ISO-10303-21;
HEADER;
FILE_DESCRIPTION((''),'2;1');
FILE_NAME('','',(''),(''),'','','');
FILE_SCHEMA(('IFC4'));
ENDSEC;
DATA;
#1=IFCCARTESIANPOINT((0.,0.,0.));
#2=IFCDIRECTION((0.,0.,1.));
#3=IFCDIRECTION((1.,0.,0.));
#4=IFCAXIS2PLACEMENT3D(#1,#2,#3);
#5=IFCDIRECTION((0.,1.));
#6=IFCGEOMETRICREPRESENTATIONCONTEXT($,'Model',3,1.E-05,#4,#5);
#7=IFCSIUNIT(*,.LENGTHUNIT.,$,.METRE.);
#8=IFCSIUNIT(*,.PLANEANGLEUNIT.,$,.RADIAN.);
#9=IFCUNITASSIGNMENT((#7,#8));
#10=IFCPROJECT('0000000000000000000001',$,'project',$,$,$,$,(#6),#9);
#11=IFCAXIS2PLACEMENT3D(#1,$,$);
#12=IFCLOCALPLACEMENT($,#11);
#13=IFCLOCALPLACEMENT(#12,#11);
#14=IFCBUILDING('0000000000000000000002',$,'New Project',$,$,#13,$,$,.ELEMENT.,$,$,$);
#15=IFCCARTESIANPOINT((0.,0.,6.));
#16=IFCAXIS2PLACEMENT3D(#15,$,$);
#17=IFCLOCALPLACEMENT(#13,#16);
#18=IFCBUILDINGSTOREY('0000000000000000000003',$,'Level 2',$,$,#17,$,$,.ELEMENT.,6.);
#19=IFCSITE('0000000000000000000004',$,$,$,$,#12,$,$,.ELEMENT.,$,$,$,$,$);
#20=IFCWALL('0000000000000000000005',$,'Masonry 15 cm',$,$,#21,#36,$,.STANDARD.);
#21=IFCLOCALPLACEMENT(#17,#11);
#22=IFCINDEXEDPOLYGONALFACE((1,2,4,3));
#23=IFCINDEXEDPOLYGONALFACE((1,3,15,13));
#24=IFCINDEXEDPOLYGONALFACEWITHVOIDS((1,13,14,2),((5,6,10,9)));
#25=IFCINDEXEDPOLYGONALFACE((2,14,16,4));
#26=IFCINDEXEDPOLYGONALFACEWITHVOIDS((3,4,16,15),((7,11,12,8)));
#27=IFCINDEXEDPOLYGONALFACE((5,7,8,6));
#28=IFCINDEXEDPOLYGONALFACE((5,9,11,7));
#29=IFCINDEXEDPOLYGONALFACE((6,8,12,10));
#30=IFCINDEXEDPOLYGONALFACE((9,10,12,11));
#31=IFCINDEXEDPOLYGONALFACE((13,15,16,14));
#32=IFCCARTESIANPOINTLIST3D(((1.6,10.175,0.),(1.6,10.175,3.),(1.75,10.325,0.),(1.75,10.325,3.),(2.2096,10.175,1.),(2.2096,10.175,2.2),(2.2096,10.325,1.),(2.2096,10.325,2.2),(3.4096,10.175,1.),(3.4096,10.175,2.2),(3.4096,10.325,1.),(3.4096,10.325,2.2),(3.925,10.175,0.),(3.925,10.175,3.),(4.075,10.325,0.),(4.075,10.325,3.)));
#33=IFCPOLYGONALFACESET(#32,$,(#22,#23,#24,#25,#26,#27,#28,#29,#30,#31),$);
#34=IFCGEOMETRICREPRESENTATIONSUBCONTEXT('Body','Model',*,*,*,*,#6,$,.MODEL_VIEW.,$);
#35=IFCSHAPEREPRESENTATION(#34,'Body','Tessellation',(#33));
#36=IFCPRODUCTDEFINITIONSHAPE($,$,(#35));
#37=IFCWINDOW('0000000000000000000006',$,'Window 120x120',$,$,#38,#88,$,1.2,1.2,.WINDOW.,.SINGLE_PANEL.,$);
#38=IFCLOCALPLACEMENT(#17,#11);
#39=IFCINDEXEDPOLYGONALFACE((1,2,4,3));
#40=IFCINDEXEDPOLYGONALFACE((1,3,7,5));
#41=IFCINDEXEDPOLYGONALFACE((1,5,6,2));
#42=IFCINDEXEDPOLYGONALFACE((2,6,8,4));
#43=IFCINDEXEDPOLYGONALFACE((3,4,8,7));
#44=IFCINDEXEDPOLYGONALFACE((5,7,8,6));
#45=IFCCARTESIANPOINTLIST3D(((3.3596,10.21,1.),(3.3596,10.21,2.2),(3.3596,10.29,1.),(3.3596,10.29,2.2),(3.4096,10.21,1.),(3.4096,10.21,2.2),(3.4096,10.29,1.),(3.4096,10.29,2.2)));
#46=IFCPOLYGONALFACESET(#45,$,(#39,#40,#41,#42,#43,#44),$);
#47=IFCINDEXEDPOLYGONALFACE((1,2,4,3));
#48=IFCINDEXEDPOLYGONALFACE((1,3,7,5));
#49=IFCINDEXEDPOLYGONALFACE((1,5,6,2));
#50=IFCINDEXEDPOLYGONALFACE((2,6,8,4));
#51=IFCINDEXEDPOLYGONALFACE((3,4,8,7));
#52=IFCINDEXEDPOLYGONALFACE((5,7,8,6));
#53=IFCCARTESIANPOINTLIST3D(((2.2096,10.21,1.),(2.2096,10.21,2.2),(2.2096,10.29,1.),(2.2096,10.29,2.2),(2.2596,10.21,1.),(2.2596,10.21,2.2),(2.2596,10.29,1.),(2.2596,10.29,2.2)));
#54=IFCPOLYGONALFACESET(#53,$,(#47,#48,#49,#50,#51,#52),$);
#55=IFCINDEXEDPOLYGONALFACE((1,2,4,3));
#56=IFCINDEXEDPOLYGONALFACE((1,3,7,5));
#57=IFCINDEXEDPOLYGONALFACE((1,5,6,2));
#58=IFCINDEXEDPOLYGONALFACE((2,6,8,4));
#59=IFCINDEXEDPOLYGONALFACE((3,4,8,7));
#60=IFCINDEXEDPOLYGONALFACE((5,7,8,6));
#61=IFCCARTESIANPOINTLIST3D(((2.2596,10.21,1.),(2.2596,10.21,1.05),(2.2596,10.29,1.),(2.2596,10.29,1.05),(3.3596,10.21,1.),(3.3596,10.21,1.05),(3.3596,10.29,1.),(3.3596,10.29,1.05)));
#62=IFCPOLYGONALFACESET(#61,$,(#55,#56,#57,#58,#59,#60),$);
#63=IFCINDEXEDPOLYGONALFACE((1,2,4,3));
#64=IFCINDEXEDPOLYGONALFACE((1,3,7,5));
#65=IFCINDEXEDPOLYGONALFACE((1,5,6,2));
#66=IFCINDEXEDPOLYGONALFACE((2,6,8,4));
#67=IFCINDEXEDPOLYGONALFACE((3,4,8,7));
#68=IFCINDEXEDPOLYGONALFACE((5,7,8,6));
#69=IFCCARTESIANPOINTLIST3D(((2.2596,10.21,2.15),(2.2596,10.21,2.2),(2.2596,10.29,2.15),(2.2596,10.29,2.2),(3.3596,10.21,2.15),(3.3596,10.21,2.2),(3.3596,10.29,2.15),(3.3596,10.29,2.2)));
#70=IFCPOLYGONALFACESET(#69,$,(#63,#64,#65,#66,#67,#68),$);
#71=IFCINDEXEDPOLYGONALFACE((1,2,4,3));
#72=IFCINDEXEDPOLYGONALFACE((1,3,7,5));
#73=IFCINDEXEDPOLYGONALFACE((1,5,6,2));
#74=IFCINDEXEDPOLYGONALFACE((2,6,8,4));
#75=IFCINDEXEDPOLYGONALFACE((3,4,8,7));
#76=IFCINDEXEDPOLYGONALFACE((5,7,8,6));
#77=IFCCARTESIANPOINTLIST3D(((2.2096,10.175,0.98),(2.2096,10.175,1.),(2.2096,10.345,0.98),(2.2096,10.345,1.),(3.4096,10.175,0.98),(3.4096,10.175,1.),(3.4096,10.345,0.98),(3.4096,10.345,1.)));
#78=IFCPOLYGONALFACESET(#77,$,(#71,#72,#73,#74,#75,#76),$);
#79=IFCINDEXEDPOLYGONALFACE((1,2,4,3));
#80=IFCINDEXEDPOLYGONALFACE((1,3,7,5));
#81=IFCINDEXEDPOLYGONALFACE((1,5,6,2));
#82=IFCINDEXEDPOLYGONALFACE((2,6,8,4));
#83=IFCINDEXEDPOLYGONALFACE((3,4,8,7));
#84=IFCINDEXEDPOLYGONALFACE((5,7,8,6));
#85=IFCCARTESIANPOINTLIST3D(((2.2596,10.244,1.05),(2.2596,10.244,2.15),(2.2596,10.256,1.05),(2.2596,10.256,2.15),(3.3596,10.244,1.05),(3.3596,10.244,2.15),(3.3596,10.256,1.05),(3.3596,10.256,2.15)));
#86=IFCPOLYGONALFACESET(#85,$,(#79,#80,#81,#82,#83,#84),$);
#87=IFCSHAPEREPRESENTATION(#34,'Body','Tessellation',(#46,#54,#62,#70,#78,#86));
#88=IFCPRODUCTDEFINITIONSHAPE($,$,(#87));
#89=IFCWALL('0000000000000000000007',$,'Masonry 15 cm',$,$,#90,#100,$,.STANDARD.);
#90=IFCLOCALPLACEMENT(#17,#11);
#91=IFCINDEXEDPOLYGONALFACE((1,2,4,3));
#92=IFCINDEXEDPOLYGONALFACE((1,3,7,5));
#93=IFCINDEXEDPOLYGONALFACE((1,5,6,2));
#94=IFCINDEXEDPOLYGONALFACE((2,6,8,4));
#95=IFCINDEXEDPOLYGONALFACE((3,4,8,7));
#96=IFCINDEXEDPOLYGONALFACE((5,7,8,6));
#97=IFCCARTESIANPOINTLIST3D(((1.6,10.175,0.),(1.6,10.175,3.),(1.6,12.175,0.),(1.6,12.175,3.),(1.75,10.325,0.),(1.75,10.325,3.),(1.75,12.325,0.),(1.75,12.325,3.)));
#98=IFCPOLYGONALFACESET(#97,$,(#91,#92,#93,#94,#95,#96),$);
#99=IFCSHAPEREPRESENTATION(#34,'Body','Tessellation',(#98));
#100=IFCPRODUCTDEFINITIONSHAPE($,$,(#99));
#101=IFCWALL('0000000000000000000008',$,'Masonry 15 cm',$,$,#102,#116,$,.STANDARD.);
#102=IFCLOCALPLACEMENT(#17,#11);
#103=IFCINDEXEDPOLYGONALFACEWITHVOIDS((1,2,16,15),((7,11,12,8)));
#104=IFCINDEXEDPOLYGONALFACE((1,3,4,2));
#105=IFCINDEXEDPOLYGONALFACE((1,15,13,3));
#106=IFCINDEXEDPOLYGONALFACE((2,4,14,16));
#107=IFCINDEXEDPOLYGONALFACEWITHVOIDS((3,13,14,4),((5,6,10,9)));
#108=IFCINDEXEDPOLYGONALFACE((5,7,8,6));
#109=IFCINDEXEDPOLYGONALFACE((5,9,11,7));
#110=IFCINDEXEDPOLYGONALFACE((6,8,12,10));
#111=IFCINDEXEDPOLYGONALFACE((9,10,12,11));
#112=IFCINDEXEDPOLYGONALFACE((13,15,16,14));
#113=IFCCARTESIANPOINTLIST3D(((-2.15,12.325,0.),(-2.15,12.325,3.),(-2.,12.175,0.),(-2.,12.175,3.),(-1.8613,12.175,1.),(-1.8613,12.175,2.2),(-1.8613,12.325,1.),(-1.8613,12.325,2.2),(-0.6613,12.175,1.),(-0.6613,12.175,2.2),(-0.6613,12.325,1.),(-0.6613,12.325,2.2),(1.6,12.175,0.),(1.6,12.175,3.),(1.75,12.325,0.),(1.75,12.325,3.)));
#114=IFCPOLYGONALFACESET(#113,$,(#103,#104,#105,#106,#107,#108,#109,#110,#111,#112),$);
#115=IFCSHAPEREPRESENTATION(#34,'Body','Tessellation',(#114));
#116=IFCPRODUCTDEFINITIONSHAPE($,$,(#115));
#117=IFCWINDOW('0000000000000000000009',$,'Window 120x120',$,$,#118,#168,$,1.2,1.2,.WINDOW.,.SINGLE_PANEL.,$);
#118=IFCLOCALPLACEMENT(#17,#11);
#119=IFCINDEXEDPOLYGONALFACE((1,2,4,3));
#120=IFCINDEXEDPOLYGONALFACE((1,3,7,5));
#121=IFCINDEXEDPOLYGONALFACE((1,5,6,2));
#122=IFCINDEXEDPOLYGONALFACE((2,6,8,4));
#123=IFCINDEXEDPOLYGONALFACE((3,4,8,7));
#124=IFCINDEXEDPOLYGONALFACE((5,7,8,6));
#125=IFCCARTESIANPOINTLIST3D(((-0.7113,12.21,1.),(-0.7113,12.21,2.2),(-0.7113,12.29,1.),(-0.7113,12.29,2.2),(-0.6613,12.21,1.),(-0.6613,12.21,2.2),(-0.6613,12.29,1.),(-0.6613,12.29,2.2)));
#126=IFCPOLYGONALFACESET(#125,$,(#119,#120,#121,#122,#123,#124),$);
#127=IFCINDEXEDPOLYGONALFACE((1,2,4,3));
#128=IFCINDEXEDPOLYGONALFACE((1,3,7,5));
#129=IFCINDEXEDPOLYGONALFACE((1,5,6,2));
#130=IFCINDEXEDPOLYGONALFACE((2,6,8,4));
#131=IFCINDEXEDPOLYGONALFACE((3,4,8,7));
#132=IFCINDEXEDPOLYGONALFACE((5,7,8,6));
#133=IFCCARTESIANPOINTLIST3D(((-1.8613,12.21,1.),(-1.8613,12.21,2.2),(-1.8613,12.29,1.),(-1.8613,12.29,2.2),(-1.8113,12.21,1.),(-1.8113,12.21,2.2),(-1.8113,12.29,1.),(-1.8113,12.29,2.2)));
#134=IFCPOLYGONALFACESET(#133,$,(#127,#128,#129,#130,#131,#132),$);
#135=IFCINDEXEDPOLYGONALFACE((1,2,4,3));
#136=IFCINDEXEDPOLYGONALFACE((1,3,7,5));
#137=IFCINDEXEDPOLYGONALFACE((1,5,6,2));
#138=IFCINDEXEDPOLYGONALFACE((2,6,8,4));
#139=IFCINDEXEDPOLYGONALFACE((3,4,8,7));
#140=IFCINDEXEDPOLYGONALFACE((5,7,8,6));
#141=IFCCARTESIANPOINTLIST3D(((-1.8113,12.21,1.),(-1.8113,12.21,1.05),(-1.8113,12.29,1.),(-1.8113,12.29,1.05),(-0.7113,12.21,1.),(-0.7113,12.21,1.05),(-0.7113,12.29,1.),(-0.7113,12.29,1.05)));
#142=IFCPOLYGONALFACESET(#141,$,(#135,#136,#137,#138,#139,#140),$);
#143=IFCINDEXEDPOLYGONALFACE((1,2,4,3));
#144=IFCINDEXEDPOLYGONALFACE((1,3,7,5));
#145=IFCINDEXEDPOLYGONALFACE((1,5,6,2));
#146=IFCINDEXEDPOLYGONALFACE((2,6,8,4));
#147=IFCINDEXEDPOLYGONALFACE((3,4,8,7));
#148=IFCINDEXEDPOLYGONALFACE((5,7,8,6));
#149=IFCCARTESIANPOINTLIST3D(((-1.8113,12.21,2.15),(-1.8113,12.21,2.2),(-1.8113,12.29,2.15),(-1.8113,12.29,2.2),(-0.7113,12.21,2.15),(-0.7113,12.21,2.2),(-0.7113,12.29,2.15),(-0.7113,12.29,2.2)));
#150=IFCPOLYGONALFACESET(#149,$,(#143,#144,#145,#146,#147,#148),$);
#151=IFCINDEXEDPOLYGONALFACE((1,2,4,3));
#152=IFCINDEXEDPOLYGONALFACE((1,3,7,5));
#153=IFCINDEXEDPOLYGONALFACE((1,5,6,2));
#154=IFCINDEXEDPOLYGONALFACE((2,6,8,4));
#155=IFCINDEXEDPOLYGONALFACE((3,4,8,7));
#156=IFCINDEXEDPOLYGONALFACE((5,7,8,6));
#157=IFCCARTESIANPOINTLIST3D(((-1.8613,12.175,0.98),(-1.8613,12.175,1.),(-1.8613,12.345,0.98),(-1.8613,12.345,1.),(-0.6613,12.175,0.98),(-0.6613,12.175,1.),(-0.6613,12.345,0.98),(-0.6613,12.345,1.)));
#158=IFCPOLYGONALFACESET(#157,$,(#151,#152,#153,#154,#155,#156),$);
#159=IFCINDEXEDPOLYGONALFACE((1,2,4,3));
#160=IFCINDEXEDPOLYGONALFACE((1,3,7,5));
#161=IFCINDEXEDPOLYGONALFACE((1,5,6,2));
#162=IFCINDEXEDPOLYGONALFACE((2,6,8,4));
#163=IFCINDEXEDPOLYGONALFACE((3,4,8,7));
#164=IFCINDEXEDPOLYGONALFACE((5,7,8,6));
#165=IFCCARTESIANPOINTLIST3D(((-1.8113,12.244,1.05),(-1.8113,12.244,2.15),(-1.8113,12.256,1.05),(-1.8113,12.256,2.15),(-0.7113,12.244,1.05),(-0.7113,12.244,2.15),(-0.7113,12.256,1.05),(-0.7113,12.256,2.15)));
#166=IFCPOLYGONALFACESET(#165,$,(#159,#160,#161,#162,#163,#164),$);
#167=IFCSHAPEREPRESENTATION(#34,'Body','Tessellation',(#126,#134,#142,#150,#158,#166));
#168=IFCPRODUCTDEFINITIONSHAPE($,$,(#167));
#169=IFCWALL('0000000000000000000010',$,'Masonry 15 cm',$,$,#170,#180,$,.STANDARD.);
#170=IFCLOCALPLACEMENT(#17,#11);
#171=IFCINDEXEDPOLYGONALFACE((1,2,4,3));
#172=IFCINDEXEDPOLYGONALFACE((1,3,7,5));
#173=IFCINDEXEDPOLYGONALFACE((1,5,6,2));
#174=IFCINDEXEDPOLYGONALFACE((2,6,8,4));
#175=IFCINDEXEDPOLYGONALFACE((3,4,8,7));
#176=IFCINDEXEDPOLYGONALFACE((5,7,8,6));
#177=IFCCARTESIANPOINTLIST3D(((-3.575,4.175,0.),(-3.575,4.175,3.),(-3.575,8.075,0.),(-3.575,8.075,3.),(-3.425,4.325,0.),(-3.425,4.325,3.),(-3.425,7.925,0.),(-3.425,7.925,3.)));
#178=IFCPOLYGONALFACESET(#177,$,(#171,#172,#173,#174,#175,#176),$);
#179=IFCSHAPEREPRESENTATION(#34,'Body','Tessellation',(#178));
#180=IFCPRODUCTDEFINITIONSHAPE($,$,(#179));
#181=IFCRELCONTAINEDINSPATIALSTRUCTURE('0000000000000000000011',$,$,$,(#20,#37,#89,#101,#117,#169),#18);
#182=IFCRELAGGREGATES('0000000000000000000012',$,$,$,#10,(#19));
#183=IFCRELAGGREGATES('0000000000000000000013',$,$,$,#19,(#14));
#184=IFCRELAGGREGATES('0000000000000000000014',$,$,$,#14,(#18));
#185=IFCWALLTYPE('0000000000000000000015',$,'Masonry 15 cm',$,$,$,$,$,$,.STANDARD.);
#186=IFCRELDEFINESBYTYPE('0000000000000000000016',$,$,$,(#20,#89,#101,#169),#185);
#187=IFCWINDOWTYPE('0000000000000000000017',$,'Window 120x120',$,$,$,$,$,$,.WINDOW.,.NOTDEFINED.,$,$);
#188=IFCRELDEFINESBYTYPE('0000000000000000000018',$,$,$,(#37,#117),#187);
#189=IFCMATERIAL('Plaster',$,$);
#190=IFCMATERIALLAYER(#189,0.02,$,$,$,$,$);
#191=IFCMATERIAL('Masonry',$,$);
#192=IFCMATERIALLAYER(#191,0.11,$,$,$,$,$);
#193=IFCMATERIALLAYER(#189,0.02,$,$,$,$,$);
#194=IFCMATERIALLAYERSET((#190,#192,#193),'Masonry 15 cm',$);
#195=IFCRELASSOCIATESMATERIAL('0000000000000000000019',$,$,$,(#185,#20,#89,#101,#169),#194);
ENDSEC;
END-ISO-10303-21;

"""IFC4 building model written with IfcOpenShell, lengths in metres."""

from ifc_helpers import new_model, si_unit, direction, frame, frame_2d, origin, origin_with_axes, place, context, subcontext, project, spatial, polyline, rectangle, outline, extrude, material, layer, layer_set, layer_usage, type_object, element, fill, save


model = new_model("IFC4")

# Units and contexts
model_context = context("Model", 3, precision=1e-05, world=origin_with_axes(), true_north=direction((0.0, 1.0)))
body_context = subcontext(model_context, "Body", "Model", "MODEL_VIEW")
ifc_project = project(units=[si_unit("LENGTHUNIT", "METRE"), si_unit("PLANEANGLEUNIT", "RADIAN")], contexts=[model_context])

# Site, building, storey
site_placement = place(None, origin())
site = spatial("IfcSite", under=ifc_project, at=site_placement, CompositionType="ELEMENT")
building_placement = place(site_placement, origin())
building = spatial("IfcBuilding", under=site, at=building_placement, Name="New Project", CompositionType="ELEMENT")
storey_placement = place(building_placement, frame((0.0, 0.0, 6.0)))
storey = spatial("IfcBuildingStorey", under=building, at=storey_placement, Name="Level 2", CompositionType="ELEMENT", Elevation=6.0)

# Wall, opening, window
ifc_material_1 = material(Name="Plaster")
ifc_layer_1 = layer(ifc_material_1, 0.02)
ifc_material_2 = material(Name="Masonry")
ifc_layer_2 = layer(ifc_material_2, 0.11)
ifc_layer_3 = layer(ifc_material_1, 0.02)
ifc_layer_set_1 = layer_set([ifc_layer_1, ifc_layer_2, ifc_layer_3], Name="Masonry 15 cm")
ifc_layer_usage_1 = layer_usage(ifc_layer_set_1, "AXIS2", "NEGATIVE", 0.075)
wall_type = type_object("IfcWallType", Name="Masonry 15 cm", PredefinedType="STANDARD", material=ifc_layer_set_1)
window_type = type_object("IfcWindowType", Name="Window 120x120", PartitioningType="NOTDEFINED", PredefinedType="WINDOW")
wall_1_placement = place(storey_placement, frame((1.675, 10.25, 0.0)))
wall_1 = element("IfcWall", 1, at=wall_1_placement, inside=storey, type_object=wall_type, material=ifc_layer_usage_1, Name="Masonry 15 cm", PredefinedType="STANDARD", context=body_context, shape_type="SweptSolid", body=[
    extrude(outline(polyline([(-0.075, -0.075), (2.25, -0.075), (2.4, 0.075), (0.075, 0.075), (-0.075, -0.075)])), origin(), (0.0, 0.0, 1.0), 3.0),
])
opening_1_placement = place(wall_1_placement, frame((0.5346, 0.0, 1.0)))
opening_1 = element("IfcOpeningElement", 2, at=opening_1_placement, cuts=wall_1, PredefinedType="OPENING", context=body_context, shape_type="SweptSolid", body=[
    extrude(rectangle(XDim=1.2, YDim=0.25, at=frame_2d((0.6, 0.0))), origin(), (0.0, 0.0, 1.0), 1.2),
])
window_1_placement = place(opening_1_placement, origin())
window_1 = element("IfcWindow", 3, at=window_1_placement, inside=storey, type_object=window_type, Name="Window 120x120", OverallHeight=1.2, OverallWidth=1.2, PartitioningType="SINGLE_PANEL", PredefinedType="WINDOW", context=body_context, shape_type="SweptSolid", body=[
    extrude(outline(polyline([(1.2, 0.04), (1.15, 0.04), (1.15, -0.04), (1.2, -0.04), (1.2, 0.04)])), origin(), (0.0, 0.0, 1.0), 1.2),
    extrude(outline(polyline([(0.05, 0.04), (0.0, 0.04), (0.0, -0.04), (0.05, -0.04), (0.05, 0.04)])), origin(), (0.0, 0.0, 1.0), 1.2),
    extrude(outline(polyline([(1.15, 0.04), (0.05, 0.04), (0.05, -0.04), (1.15, -0.04), (1.15, 0.04)])), origin(), (0.0, 0.0, 1.0), 0.05),
    extrude(outline(polyline([(1.15, 0.04), (0.05, 0.04), (0.05, -0.04), (1.15, -0.04), (1.15, 0.04)])), frame((0.0, 0.0, 1.15)), (0.0, 0.0, 1.0), 0.05),
    extrude(outline(polyline([(1.2, 0.095), (0.0, 0.095), (0.0, -0.075), (1.2, -0.075), (1.2, 0.095)])), frame((0.0, 0.0, -0.02)), (0.0, 0.0, 1.0), 0.02),
    extrude(outline(polyline([(1.15, 0.006), (0.05, 0.006), (0.05, -0.006), (1.15, -0.006), (1.15, 0.006)])), frame((0.0, 0.0, 0.05)), (0.0, 0.0, 1.0), 1.1),
])
fill(opening_1, window_1)

# Wall
wall_2_placement = place(storey_placement, frame((1.675, 12.25, 0.0), z_axis=(0.0, 0.0, 1.0), x_axis=(0.0, -1.0, 0.0)))
element("IfcWall", 4, at=wall_2_placement, inside=storey, type_object=wall_type, material=ifc_layer_usage_1, Name="Masonry 15 cm", PredefinedType="STANDARD", context=body_context, shape_type="SweptSolid", body=[
    extrude(outline(polyline([(0.075, -0.075), (2.075, -0.075), (1.925, 0.075), (-0.075, 0.075), (0.075, -0.075)])), origin(), (0.0, 0.0, 1.0), 3.0),
])

# Wall, opening, window
wall_3_placement = place(storey_placement, frame((-2.075, 12.25, 0.0)))
wall_3 = element("IfcWall", 5, at=wall_3_placement, inside=storey, type_object=wall_type, material=ifc_layer_usage_1, Name="Masonry 15 cm", PredefinedType="STANDARD", context=body_context, shape_type="SweptSolid", body=[
    extrude(outline(polyline([(0.075, -0.075), (3.675, -0.075), (3.825, 0.075), (-0.075, 0.075), (0.075, -0.075)])), origin(), (0.0, 0.0, 1.0), 3.0),
])
opening_2_placement = place(wall_3_placement, frame((0.2137, 0.0, 1.0)))
opening_2 = element("IfcOpeningElement", 6, at=opening_2_placement, cuts=wall_3, PredefinedType="OPENING", context=body_context, shape_type="SweptSolid", body=[
    extrude(rectangle(XDim=1.2, YDim=0.25, at=frame_2d((0.6, 0.0))), origin(), (0.0, 0.0, 1.0), 1.2),
])
window_2_placement = place(opening_2_placement, origin())
window_2 = element("IfcWindow", 7, at=window_2_placement, inside=storey, type_object=window_type, Name="Window 120x120", OverallHeight=1.2, OverallWidth=1.2, PartitioningType="SINGLE_PANEL", PredefinedType="WINDOW", context=body_context, shape_type="SweptSolid", body=[
    extrude(outline(polyline([(1.2, 0.04), (1.15, 0.04), (1.15, -0.04), (1.2, -0.04), (1.2, 0.04)])), origin(), (0.0, 0.0, 1.0), 1.2),
    extrude(outline(polyline([(0.05, 0.04), (0.0, 0.04), (0.0, -0.04), (0.05, -0.04), (0.05, 0.04)])), origin(), (0.0, 0.0, 1.0), 1.2),
    extrude(outline(polyline([(1.15, 0.04), (0.05, 0.04), (0.05, -0.04), (1.15, -0.04), (1.15, 0.04)])), origin(), (0.0, 0.0, 1.0), 0.05),
    extrude(outline(polyline([(1.15, 0.04), (0.05, 0.04), (0.05, -0.04), (1.15, -0.04), (1.15, 0.04)])), frame((0.0, 0.0, 1.15)), (0.0, 0.0, 1.0), 0.05),
    extrude(outline(polyline([(1.2, 0.095), (0.0, 0.095), (0.0, -0.075), (1.2, -0.075), (1.2, 0.095)])), frame((0.0, 0.0, -0.02)), (0.0, 0.0, 1.0), 0.02),
    extrude(outline(polyline([(1.15, 0.006), (0.05, 0.006), (0.05, -0.006), (1.15, -0.006), (1.15, 0.006)])), frame((0.0, 0.0, 0.05)), (0.0, 0.0, 1.0), 1.1),
])
fill(opening_2, window_2)

# Wall
wall_4_placement = place(storey_placement, frame((-3.5, 4.25, 0.0), z_axis=(0.0, 0.0, 1.0), x_axis=(0.0, 1.0, 0.0)))
element("IfcWall", 8, at=wall_4_placement, inside=storey, type_object=wall_type, material=ifc_layer_usage_1, Name="Masonry 15 cm", PredefinedType="STANDARD", context=body_context, shape_type="SweptSolid", body=[
    extrude(outline(polyline([(0.075, -0.075), (3.675, -0.075), (3.825, 0.075), (-0.075, 0.075), (0.075, -0.075)])), origin(), (0.0, 0.0, 1.0), 3.0),
])

save(model, "model.ifc")
